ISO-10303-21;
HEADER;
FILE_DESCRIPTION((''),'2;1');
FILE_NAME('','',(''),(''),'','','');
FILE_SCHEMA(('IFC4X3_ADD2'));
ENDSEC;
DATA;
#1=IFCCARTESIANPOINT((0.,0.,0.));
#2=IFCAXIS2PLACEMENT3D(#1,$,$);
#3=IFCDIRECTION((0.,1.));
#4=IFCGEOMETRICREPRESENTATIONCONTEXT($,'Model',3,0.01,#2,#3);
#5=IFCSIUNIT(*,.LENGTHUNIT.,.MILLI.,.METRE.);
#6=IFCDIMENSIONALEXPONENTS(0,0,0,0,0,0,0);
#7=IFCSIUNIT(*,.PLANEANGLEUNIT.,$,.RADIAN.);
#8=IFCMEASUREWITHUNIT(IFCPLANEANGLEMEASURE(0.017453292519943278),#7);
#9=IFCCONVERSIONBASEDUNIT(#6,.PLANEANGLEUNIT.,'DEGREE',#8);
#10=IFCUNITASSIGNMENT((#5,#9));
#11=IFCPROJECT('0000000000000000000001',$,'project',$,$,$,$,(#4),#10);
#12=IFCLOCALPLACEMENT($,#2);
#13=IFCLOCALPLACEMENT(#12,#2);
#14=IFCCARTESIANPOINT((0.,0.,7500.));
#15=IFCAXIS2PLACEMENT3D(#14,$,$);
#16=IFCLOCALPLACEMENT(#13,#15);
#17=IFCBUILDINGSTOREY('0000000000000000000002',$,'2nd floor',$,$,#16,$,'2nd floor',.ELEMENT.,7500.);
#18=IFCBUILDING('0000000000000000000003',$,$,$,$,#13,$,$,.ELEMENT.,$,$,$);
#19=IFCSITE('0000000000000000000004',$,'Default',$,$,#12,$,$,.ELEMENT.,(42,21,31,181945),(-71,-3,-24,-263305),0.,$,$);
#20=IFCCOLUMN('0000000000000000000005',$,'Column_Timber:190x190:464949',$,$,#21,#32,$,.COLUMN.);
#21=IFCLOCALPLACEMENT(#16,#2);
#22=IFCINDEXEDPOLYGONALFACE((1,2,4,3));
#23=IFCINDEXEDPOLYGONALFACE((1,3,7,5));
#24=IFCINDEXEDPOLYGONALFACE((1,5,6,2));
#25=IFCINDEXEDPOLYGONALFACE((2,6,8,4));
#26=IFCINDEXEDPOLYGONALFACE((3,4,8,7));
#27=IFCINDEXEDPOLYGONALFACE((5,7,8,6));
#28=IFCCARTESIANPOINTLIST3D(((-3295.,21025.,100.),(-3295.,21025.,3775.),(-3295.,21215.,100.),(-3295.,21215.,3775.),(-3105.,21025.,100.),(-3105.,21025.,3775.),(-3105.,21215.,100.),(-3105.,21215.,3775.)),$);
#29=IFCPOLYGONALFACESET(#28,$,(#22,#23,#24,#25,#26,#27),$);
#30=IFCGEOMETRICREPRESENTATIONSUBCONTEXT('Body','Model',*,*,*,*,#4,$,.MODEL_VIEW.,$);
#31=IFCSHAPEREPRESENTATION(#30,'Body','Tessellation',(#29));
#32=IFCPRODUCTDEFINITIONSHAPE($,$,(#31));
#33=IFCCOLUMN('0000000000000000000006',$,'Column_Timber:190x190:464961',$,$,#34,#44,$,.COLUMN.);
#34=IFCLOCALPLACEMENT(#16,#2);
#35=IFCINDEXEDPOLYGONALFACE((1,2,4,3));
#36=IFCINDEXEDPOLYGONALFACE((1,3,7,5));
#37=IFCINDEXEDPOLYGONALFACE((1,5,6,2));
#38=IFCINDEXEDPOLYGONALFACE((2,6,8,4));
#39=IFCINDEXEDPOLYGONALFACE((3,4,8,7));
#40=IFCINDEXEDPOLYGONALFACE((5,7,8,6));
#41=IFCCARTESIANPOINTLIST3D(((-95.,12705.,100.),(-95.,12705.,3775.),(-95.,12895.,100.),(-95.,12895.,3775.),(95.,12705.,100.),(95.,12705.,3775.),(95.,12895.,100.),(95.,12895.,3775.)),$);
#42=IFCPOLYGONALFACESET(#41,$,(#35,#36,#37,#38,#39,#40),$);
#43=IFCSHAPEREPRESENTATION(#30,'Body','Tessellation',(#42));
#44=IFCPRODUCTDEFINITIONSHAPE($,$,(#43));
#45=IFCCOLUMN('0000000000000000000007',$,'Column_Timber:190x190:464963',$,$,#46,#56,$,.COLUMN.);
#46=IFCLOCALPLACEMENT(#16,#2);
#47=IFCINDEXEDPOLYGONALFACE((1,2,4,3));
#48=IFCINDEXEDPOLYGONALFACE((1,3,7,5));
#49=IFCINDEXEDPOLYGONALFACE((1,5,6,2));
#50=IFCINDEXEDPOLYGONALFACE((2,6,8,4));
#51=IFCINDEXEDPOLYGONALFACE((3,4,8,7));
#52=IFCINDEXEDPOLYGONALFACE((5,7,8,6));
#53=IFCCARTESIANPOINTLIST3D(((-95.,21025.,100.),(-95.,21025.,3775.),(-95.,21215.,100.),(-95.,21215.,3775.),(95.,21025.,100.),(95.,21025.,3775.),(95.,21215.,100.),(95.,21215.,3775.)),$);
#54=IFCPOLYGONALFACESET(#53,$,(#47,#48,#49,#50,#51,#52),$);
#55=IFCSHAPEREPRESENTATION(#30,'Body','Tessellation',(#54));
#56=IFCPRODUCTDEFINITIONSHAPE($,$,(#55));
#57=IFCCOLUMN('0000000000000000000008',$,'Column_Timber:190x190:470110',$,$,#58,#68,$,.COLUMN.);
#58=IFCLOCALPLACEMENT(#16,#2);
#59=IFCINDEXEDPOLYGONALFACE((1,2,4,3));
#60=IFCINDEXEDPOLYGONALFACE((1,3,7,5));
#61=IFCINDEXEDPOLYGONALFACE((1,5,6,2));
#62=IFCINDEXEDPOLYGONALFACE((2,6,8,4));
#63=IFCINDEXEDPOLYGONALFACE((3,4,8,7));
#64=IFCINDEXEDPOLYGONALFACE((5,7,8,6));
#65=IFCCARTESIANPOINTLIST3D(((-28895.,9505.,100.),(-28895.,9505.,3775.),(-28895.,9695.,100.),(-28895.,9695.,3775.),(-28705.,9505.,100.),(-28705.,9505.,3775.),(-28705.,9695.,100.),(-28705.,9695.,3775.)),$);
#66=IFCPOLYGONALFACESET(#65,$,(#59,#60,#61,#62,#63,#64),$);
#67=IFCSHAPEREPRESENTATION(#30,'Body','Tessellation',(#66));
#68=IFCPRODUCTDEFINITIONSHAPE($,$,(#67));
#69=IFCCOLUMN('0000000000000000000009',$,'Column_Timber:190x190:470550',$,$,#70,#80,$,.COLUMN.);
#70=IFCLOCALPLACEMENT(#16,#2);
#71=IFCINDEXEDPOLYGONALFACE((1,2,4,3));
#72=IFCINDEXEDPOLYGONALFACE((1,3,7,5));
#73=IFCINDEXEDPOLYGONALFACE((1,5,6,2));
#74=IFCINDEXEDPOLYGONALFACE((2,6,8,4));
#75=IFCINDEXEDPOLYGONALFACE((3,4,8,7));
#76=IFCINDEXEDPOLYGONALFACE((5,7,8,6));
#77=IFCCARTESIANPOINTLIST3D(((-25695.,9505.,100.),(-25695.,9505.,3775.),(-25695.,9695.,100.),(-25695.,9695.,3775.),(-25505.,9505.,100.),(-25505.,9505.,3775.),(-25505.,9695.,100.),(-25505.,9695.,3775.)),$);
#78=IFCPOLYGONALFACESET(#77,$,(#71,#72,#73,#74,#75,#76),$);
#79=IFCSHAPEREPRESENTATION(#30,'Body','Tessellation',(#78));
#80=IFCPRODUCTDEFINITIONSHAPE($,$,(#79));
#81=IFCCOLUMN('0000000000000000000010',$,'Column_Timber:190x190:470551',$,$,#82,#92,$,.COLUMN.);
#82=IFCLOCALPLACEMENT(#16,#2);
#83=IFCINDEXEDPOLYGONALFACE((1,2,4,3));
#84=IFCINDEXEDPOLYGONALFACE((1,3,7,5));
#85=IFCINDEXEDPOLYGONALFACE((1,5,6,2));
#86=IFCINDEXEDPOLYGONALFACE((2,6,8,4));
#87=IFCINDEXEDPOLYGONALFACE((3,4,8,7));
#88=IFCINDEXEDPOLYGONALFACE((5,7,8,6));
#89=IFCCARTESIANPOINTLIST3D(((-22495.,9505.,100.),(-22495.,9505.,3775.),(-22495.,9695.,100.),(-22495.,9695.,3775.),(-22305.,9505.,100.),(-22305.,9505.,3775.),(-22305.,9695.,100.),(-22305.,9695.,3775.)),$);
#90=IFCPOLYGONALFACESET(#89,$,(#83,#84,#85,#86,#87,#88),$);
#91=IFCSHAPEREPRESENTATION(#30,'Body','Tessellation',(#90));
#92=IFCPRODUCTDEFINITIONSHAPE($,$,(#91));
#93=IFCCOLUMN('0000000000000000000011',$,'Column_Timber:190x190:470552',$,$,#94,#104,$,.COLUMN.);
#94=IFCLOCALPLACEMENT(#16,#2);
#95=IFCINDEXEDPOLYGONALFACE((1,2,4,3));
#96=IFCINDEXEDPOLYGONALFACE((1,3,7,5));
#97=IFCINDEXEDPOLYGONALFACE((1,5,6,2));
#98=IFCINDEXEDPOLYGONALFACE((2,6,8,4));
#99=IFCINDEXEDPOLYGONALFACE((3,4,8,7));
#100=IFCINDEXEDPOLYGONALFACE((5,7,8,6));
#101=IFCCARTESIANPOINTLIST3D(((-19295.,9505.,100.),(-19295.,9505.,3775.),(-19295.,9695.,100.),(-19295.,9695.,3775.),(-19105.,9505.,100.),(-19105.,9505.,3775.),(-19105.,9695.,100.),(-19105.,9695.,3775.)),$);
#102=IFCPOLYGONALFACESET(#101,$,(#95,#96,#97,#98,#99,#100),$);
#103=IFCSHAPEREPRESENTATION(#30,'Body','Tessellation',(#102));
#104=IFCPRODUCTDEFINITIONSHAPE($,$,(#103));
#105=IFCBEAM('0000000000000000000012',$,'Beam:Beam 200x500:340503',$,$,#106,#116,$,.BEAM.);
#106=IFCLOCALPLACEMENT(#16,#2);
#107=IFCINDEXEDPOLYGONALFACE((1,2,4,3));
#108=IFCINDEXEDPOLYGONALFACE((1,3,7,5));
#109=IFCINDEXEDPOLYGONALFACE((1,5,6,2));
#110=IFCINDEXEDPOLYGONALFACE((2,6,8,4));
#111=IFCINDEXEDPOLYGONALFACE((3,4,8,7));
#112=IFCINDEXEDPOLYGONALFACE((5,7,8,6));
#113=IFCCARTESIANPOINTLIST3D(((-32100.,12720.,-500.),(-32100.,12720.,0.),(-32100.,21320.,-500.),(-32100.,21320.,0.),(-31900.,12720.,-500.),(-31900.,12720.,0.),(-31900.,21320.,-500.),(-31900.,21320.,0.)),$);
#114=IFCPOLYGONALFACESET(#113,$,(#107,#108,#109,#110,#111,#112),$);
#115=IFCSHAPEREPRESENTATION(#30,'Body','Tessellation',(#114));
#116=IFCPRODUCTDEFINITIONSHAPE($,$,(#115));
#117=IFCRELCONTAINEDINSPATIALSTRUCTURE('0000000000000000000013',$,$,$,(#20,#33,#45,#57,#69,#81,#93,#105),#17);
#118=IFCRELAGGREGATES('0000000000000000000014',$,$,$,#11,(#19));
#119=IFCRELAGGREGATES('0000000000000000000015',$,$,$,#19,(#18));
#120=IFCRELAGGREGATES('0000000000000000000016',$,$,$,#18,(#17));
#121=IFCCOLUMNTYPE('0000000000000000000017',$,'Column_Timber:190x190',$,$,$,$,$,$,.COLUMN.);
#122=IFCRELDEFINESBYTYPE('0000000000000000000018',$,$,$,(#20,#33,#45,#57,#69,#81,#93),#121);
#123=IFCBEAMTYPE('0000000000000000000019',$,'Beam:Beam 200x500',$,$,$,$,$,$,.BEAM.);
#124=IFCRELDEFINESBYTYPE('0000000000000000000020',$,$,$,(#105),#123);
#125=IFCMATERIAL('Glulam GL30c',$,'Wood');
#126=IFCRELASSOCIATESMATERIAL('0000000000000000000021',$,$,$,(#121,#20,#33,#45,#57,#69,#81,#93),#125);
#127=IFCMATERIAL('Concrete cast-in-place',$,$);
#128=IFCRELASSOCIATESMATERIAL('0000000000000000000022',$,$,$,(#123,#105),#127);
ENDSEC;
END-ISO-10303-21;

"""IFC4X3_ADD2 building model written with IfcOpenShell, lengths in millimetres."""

from ifc_helpers import new_model, entity, si_unit, converted_unit, direction, frame, origin, origin_2d_with_axis, place, context, subcontext, project, spatial, rectangle, extrude, source, transform, mapped, material, material_profile, profile_set, profile_usage, type_object, type_shapes, element, save


model = new_model("IFC4X3_ADD2")

# Units and contexts
model_context = context("Model", 3, precision=0.01, world=origin(), true_north=direction((0.0, 1.0)))
body_context = subcontext(model_context, "Body", "Model", "MODEL_VIEW")
ifc_project = project(units=[si_unit("LENGTHUNIT", "METRE", prefix="MILLI"), converted_unit("PLANEANGLEUNIT", "DEGREE", entity("IfcPlaneAngleMeasure", 0.017453292519943278), si_unit("PLANEANGLEUNIT", "RADIAN"), dimensions=[0, 0, 0, 0, 0, 0, 0])], contexts=[model_context])

# Site, building, storey
site_placement = place(None, origin())
site = spatial("IfcSite", under=ifc_project, at=site_placement, Name="Default", CompositionType="ELEMENT", RefLatitude=(42, 21, 31, 181945), RefLongitude=(-71, -3, -24, -263305), RefElevation=0.0)
building_placement = place(site_placement, origin())
building = spatial("IfcBuilding", under=site, at=building_placement, CompositionType="ELEMENT")
storey_placement = place(building_placement, frame((0.0, 0.0, 7500.0)))
storey = spatial("IfcBuildingStorey", under=building, at=storey_placement, Name="2nd floor", LongName="2nd floor", CompositionType="ELEMENT", Elevation=7500.0)

# Columns
ifc_material_1 = material(Name="Glulam GL30c", Category="Wood")
ifc_material_profile_1 = material_profile(ifc_material_1, rectangle(XDim=190.0, YDim=190.0, at=origin_2d_with_axis()), Name="190x190")
ifc_profile_set_1 = profile_set([ifc_material_profile_1], Name="190x190")
ifc_profile_usage_1 = profile_usage(ifc_profile_set_1)
column_type = type_object("IfcColumnType", Name="Column_Timber:190x190", PredefinedType="COLUMN", material=ifc_profile_set_1)
shared_shape_1 = source(origin(), body_context, "Body", "SweptSolid", [
    extrude(rectangle(XDim=190.0, YDim=190.0, at=origin_2d_with_axis()), frame((0.0, 0.0, 7600.0), z_axis=(0.0, 0.0, 1.0), x_axis=(-1.0, 0.0, 0.0)), (0.0, 0.0, 1.0), 3675.0),
])
type_shapes(column_type, [shared_shape_1])
for number, where, name in (
    (1, (-3200.0, 21120.0, -7500.0), "Column_Timber:190x190:464949"),
    (2, (0.0, 12800.0, -7500.0), "Column_Timber:190x190:464961"),
    (3, (0.0, 21120.0, -7500.0), "Column_Timber:190x190:464963"),
    (4, (-28800.0, 9600.0, -7500.0), "Column_Timber:190x190:470110"),
    (5, (-25600.0, 9600.0, -7500.0), "Column_Timber:190x190:470550"),
    (6, (-22400.0, 9600.0, -7500.0), "Column_Timber:190x190:470551"),
    (7, (-19200.0, 9600.0, -7500.0), "Column_Timber:190x190:470552"),
):
    element("IfcColumn", number, at=place(storey_placement, frame(where)), inside=storey, type_object=column_type, material=ifc_profile_usage_1, Name=name, PredefinedType="COLUMN", context=body_context, shape_type="MappedRepresentation", body=[
        mapped(shared_shape_1, transform((0.0, 0.0, 0.0), scale=1.0)),
    ])

# Beam
ifc_material_2 = material(Name="Concrete cast-in-place")
ifc_material_profile_2 = material_profile(ifc_material_2, rectangle(XDim=8600.0, YDim=200.0, at=origin_2d_with_axis()), Name="Beam 200x500")
ifc_profile_set_2 = profile_set([ifc_material_profile_2], Name="Beam 200x500")
ifc_profile_usage_2 = profile_usage(ifc_profile_set_2, cardinal=8)
beam_type_1 = type_object("IfcBeamType", Name="Beam:Beam 200x500", PredefinedType="BEAM", material=ifc_profile_set_2)
shared_shape_2 = source(origin(), body_context, "Body", "SweptSolid", [
    extrude(rectangle(XDim=8600.0, YDim=200.0, at=origin_2d_with_axis()), frame((0.0, 0.0, -260.0), z_axis=(0.0, 0.0, 1.0), x_axis=(-1.0, 0.0, 0.0)), (0.0, 0.0, 1.0), 500.0),
])
type_shapes(beam_type_1, [shared_shape_2])
beam_1_placement = place(storey_placement, frame((-32000.0, 17020.0, -240.0), z_axis=(0.0, 0.0, 1.0), x_axis=(0.0, -1.0, 0.0)))
element("IfcBeam", 8, at=beam_1_placement, inside=storey, type_object=beam_type_1, material=ifc_profile_usage_2, Name="Beam:Beam 200x500:340503", PredefinedType="BEAM", context=body_context, shape_type="MappedRepresentation", body=[
    mapped(shared_shape_2, transform((0.0, 0.0, 0.0), scale=1.0)),
])

save(model, "model.ifc")
